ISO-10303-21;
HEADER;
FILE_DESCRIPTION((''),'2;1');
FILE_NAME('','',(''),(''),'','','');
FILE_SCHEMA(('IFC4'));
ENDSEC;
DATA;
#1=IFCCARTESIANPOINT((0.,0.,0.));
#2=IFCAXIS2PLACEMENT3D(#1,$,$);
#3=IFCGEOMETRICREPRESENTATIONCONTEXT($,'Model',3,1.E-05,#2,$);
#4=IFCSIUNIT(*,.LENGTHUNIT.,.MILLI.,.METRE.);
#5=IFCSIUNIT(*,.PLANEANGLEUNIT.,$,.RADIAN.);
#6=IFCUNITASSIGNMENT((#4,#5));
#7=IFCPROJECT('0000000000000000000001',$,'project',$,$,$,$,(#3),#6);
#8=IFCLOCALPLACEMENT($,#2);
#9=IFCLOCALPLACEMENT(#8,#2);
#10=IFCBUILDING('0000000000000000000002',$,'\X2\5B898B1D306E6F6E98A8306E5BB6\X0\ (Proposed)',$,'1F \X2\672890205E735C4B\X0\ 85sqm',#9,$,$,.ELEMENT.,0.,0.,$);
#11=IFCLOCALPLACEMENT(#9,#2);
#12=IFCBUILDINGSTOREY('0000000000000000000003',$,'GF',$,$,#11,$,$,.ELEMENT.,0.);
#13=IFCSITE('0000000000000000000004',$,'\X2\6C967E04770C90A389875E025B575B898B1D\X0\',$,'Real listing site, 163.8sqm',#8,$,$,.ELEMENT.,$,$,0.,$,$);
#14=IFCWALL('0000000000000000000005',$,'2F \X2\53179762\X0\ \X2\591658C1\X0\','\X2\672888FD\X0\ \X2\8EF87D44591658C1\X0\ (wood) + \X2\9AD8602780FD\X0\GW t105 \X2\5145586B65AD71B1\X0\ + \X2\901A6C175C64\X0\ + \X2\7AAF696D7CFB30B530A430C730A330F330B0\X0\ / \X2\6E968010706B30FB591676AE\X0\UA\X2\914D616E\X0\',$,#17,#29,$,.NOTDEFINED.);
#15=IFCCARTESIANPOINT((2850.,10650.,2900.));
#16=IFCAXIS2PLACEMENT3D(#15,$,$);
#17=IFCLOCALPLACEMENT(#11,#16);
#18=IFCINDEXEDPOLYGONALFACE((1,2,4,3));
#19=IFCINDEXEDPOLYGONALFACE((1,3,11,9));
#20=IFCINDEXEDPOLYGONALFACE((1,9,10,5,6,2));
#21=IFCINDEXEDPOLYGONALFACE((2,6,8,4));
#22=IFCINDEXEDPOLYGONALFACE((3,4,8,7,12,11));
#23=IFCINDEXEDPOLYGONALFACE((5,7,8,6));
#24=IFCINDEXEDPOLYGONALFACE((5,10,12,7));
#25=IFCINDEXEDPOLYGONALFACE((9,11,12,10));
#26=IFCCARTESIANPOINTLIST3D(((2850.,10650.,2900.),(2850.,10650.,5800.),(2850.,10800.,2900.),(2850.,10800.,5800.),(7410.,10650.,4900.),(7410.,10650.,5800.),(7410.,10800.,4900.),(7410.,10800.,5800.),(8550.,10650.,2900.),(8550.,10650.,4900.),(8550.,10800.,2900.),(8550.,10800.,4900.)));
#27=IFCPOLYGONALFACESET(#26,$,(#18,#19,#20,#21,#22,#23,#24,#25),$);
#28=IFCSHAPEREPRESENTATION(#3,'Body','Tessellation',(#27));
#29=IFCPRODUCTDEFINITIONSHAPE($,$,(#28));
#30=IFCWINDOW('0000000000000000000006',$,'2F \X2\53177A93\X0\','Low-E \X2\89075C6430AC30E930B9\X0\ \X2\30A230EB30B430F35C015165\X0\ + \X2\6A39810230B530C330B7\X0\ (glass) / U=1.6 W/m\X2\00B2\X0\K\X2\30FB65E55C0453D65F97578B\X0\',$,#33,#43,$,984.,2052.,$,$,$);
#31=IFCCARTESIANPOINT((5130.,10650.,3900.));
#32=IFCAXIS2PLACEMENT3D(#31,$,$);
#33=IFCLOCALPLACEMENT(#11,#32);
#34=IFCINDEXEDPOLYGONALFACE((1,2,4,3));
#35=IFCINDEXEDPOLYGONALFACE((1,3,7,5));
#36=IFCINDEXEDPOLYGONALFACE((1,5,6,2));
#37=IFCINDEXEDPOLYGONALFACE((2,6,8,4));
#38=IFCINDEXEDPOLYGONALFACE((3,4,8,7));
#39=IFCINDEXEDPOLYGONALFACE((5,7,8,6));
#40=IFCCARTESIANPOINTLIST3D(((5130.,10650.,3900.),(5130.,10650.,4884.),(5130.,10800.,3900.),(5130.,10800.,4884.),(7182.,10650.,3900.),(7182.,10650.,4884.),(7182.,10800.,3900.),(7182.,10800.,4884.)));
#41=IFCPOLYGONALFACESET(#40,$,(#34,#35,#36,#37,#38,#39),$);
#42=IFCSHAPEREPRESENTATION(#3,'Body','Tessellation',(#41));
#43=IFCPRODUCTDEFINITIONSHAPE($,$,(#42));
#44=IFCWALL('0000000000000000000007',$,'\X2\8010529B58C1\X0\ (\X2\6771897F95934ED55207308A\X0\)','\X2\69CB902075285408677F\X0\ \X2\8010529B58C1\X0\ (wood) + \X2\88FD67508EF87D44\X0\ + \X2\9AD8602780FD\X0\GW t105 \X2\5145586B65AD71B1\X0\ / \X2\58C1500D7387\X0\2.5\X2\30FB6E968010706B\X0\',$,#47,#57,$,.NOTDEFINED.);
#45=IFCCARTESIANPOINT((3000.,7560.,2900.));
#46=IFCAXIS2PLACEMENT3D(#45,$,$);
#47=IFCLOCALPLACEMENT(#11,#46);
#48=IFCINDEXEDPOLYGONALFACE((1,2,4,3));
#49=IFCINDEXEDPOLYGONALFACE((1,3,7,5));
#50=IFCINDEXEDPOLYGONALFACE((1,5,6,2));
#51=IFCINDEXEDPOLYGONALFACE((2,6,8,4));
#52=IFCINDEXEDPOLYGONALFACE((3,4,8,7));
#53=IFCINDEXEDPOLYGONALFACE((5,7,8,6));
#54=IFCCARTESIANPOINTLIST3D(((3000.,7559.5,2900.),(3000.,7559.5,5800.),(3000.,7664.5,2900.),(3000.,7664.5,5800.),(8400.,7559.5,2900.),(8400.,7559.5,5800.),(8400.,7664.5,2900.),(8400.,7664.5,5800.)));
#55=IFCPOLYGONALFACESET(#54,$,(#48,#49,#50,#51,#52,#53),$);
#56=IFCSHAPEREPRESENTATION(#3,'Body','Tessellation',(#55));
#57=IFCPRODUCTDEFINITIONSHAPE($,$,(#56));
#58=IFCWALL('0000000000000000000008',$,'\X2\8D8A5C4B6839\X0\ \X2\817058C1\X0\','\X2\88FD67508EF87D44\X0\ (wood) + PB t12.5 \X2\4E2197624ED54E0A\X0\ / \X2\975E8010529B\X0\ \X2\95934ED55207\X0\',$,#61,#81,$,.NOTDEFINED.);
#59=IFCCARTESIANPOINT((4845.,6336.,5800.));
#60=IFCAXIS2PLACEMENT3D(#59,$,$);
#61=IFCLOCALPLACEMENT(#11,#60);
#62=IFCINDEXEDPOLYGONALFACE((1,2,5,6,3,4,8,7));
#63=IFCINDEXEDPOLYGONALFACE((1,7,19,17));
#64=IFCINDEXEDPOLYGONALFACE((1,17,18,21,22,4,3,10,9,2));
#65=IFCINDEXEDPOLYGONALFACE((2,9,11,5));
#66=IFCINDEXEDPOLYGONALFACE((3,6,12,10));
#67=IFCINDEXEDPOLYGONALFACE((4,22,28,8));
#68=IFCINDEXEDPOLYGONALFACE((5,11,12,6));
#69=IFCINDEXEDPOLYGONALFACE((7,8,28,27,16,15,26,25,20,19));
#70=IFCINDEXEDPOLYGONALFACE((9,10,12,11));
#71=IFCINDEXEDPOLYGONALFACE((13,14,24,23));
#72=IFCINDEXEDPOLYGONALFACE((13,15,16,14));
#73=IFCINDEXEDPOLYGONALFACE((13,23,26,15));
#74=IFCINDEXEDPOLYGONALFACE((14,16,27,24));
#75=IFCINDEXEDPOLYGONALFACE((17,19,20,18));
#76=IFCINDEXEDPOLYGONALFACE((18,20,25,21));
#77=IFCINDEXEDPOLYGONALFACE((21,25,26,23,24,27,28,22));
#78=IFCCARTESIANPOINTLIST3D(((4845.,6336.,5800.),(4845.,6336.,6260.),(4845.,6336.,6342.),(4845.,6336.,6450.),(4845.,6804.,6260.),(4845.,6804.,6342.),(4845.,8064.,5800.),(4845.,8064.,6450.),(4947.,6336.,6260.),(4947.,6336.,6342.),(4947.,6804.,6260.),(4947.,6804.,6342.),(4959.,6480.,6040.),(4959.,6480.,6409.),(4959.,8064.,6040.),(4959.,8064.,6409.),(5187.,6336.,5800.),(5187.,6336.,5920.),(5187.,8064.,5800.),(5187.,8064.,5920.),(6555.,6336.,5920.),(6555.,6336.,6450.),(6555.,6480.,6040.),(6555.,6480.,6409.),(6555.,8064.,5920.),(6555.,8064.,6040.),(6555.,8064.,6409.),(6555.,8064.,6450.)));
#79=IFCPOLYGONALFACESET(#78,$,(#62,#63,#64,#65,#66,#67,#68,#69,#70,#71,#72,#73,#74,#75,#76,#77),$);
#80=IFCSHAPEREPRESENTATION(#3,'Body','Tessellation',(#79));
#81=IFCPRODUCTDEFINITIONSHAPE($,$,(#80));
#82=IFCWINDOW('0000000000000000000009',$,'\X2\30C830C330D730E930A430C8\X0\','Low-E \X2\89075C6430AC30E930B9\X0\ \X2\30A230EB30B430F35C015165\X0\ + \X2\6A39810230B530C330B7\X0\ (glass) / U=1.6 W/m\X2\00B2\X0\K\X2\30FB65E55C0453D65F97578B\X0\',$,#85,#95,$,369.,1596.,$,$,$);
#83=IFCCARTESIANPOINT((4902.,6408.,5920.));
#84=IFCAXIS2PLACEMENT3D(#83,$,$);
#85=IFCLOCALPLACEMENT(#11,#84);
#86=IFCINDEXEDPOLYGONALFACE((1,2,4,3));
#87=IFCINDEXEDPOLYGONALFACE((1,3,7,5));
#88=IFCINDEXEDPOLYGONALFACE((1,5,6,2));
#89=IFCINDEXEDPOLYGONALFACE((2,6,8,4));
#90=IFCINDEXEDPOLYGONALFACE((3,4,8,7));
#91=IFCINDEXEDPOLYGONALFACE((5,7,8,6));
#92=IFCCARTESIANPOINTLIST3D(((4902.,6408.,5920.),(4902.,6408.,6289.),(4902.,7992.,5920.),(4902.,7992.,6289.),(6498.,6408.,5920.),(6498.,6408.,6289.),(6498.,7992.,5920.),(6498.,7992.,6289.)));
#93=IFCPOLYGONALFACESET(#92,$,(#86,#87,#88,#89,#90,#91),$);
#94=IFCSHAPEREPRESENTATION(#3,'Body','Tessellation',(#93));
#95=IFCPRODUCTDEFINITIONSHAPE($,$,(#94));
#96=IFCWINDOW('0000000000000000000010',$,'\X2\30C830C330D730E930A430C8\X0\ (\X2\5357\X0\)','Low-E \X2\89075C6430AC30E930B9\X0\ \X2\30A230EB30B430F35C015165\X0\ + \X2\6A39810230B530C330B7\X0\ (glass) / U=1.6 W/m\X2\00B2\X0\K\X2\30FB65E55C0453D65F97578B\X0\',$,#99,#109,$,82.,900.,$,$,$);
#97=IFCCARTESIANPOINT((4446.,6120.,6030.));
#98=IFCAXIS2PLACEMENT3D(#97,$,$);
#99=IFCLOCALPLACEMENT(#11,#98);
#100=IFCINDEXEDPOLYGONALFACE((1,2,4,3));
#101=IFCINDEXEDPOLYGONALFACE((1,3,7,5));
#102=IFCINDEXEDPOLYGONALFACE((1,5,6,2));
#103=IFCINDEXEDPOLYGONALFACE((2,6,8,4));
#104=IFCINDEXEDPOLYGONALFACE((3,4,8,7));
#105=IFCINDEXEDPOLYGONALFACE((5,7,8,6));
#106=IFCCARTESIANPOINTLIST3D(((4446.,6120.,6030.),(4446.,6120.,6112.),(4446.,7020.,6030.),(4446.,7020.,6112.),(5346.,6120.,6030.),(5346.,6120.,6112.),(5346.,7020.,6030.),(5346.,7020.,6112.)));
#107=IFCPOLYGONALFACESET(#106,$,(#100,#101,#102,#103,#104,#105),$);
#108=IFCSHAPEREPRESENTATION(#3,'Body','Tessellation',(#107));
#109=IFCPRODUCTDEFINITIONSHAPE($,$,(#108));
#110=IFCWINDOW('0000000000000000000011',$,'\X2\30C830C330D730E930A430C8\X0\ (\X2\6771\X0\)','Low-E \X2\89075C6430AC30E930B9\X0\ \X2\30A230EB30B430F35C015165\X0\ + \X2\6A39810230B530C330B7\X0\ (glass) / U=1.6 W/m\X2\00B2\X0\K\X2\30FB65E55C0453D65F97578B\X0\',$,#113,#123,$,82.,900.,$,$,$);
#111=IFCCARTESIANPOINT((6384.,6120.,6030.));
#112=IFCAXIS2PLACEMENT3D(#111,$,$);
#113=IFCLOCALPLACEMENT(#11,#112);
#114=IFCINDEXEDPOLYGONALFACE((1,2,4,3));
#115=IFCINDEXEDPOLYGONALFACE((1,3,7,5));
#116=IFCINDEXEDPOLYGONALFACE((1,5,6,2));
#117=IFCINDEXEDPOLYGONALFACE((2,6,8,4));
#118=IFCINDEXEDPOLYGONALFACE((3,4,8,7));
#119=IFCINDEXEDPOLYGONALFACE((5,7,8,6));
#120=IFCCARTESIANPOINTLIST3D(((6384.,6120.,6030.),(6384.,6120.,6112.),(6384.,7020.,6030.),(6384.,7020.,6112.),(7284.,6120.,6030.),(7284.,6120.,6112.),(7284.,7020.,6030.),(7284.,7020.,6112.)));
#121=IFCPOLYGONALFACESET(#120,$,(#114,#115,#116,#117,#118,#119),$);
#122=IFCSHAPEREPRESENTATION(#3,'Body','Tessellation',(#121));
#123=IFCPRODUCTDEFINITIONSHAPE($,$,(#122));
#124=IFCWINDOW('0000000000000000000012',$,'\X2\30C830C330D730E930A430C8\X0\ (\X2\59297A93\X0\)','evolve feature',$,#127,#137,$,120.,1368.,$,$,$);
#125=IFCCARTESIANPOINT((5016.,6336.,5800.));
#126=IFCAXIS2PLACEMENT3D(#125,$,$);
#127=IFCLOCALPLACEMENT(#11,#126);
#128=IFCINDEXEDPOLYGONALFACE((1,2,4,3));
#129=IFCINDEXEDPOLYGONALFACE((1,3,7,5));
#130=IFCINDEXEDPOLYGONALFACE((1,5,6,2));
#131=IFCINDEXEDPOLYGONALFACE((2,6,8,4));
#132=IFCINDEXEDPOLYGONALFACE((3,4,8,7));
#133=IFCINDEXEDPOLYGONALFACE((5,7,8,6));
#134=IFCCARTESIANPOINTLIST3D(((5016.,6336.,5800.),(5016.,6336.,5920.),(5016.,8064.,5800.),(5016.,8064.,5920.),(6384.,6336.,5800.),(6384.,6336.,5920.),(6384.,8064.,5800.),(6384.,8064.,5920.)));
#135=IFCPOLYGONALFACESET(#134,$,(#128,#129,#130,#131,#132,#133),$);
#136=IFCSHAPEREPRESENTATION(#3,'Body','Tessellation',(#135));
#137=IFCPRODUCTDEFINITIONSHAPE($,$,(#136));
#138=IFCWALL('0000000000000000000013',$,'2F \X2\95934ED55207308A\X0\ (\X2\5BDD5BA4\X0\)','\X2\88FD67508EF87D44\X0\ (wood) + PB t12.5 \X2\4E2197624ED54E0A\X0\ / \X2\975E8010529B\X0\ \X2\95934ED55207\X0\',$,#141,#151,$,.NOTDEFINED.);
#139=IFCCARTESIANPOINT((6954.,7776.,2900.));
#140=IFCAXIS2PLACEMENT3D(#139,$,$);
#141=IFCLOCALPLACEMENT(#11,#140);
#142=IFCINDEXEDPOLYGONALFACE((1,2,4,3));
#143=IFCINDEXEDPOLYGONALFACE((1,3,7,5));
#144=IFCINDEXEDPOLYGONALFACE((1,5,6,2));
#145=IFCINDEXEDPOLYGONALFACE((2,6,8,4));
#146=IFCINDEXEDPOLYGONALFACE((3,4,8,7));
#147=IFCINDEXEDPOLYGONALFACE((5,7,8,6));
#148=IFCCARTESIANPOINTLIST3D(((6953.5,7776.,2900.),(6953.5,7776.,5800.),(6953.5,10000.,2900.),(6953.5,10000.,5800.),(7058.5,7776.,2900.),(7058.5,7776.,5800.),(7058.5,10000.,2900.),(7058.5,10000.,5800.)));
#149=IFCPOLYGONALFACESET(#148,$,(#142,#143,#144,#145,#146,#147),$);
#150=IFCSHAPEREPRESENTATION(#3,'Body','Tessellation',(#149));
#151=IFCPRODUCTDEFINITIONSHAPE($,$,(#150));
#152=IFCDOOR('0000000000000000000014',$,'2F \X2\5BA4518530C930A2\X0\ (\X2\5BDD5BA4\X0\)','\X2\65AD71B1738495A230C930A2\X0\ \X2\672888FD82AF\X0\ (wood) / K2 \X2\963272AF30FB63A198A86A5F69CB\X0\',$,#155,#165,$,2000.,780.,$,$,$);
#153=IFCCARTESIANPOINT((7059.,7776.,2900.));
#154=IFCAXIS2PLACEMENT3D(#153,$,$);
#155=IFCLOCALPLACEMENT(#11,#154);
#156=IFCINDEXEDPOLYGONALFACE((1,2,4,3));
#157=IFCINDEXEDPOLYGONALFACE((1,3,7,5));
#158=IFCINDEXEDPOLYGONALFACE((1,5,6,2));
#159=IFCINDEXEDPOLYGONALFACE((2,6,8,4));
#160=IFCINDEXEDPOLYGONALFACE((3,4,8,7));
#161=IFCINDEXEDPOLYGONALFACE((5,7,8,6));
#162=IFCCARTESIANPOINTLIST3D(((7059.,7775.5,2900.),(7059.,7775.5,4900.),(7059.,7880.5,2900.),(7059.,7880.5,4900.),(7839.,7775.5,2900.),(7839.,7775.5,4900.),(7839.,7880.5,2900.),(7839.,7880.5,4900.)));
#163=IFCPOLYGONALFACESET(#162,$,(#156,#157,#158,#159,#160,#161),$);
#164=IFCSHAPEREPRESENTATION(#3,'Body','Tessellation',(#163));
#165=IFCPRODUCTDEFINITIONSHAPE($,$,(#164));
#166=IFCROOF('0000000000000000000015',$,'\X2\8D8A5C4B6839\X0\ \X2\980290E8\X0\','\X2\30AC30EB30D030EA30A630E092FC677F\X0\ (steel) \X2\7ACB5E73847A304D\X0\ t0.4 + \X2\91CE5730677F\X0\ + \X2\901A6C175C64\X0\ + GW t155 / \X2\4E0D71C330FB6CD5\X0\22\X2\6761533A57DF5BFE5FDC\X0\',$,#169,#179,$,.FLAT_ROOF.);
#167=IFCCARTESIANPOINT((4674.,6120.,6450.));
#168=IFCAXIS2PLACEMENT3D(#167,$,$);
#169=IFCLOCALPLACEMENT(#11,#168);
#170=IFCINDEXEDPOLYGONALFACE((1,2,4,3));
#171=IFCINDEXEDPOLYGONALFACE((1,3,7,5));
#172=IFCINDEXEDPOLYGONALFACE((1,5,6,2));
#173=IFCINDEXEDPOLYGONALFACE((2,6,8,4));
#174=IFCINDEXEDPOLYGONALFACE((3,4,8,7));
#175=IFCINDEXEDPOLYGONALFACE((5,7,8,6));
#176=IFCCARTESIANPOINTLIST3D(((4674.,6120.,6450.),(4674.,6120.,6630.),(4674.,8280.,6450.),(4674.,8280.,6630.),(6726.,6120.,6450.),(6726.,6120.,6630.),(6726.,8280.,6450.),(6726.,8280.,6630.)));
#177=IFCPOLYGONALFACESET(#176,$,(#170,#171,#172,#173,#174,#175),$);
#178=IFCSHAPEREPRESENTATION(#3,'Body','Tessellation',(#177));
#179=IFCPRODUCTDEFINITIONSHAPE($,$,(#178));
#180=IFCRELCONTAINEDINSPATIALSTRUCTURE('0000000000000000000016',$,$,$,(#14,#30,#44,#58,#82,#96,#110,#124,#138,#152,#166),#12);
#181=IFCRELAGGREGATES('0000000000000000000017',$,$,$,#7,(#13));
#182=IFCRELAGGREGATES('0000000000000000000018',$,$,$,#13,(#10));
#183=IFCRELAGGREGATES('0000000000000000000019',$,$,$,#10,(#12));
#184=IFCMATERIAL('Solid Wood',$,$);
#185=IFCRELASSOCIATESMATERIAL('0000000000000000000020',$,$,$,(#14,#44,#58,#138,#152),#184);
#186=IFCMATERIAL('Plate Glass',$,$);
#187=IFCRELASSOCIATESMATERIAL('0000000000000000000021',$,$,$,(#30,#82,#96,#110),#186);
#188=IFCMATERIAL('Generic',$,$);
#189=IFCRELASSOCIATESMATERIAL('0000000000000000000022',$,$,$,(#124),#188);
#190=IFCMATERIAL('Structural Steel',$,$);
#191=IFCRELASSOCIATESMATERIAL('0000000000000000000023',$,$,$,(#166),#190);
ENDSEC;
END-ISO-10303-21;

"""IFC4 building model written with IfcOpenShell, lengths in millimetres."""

from ifc_helpers import new_model, si_unit, frame, frame_2d, origin, place, context, project, spatial, rectangle, extrude, material, element, fill, save


model = new_model("IFC4")

# Units and contexts
model_context = context("Model", 3, precision=1e-05, world=origin())
ifc_project = project(units=[si_unit("LENGTHUNIT", "METRE", prefix="MILLI"), si_unit("PLANEANGLEUNIT", "RADIAN")], contexts=[model_context])

# Site, building, storey
site_placement = place(None, origin())
site = spatial("IfcSite", under=ifc_project, at=site_placement, Name="沖縄県那覇市字安謝", ObjectType="Real listing site, 163.8sqm", CompositionType="ELEMENT", RefElevation=0.0)
building_placement = place(site_placement, origin())
building = spatial("IfcBuilding", under=site, at=building_placement, Name="安謝の潮風の家 (Proposed)", ObjectType="1F 木造平屋 85sqm", CompositionType="ELEMENT", ElevationOfRefHeight=0.0, ElevationOfTerrain=0.0)
storey_placement = place(building_placement, origin())
storey = spatial("IfcBuildingStorey", under=building, at=storey_placement, Name="GF", CompositionType="ELEMENT", Elevation=0.0)

# Wall, opening, window
ifc_material_1 = material(Name="Solid Wood")
wall_1_placement = place(storey_placement, frame((2850.0, 10650.0, 2900.0)))
wall_1 = element("IfcWall", 1, at=wall_1_placement, inside=storey, material=ifc_material_1, Name="2F 北面 外壁", Description="木製 軸組外壁 (wood) + 高性能GW t105 充填断熱 + 通気層 + 窯業系サイディング / 準耐火・外皮UA配慮", PredefinedType="NOTDEFINED", context=model_context, shape_type="SweptSolid", body=[
    extrude(rectangle(XDim=5700.0, YDim=150.0, at=frame_2d((2850.0, 75.0))), frame((2850.0, 10650.0, 2900.0)), (0.0, 0.0, 1.0), 2900.0),
])
opening_1_placement = place(storey_placement, frame((5130.0, 10650.0, 3900.0)))
opening_1 = element("IfcOpeningElement", 2, at=opening_1_placement, cuts=wall_1, PredefinedType="NOTDEFINED", context=model_context, shape_type="SweptSolid", body=[
    extrude(rectangle(XDim=2052.0, YDim=150.0, at=frame_2d((1026.0, 75.0))), frame((5130.0, 10650.0, 3900.0)), (0.0, 0.0, 1.0), 984.0),
])
ifc_material_2 = material(Name="Plate Glass")
window_1_placement = place(storey_placement, frame((5130.0, 10650.0, 3900.0)))
window_1 = element("IfcWindow", 3, at=window_1_placement, inside=storey, material=ifc_material_2, Name="2F 北窓", Description="Low-E 複層ガラス アルゴン封入 + 樹脂サッシ (glass) / U=1.6 W/m²K・日射取得型", OverallHeight=984.0, OverallWidth=2052.0, context=model_context, shape_type="SweptSolid", body=[
    extrude(rectangle(XDim=2052.0, YDim=150.0, at=frame_2d((1026.0, 75.0))), frame((5130.0, 10650.0, 3900.0)), (0.0, 0.0, 1.0), 984.0),
])
fill(opening_1, window_1)

# Wall
wall_2_placement = place(storey_placement, frame((3000.0, 7560.0, 2900.0)))
element("IfcWall", 4, at=wall_2_placement, inside=storey, material=ifc_material_1, Name="耐力壁 (東西間仕切り)", Description="構造用合板 耐力壁 (wood) + 製材軸組 + 高性能GW t105 充填断熱 / 壁倍率2.5・準耐火", PredefinedType="NOTDEFINED", context=model_context, shape_type="SweptSolid", body=[
    extrude(rectangle(XDim=5400.0, YDim=105.0, at=frame_2d((2700.0, 52.0))), frame((3000.0, 7560.0, 2900.0)), (0.0, 0.0, 1.0), 2900.0),
])

# Wall, openings, windows
wall_3_placement = place(storey_placement, frame((4845.0, 6336.0, 5800.0)))
wall_3 = element("IfcWall", 5, at=wall_3_placement, inside=storey, material=ifc_material_1, Name="越屋根 腰壁", Description="製材軸組 (wood) + PB t12.5 両面仕上 / 非耐力 間仕切", PredefinedType="NOTDEFINED", context=model_context, shape_type="SweptSolid", body=[
    extrude(rectangle(XDim=1710.0, YDim=1728.0, at=frame_2d((855.0, 864.0))), frame((4845.0, 6336.0, 5800.0)), (0.0, 0.0, 1.0), 650.0),
])
opening_2_placement = place(storey_placement, frame((4902.0, 6408.0, 5920.0)))
opening_2 = element("IfcOpeningElement", 6, at=opening_2_placement, cuts=wall_3, PredefinedType="NOTDEFINED", context=model_context, shape_type="SweptSolid", body=[
    extrude(rectangle(XDim=1596.0, YDim=1584.0, at=frame_2d((798.0, 792.0))), frame((4902.0, 6408.0, 5920.0)), (0.0, 0.0, 1.0), 369.0),
])
opening_3_placement = place(storey_placement, frame((4446.0, 6120.0, 6030.0)))
opening_3 = element("IfcOpeningElement", 7, at=opening_3_placement, cuts=wall_3, PredefinedType="NOTDEFINED", context=model_context, shape_type="SweptSolid", body=[
    extrude(rectangle(XDim=900.0, YDim=900.0, at=frame_2d((450.0, 450.0))), frame((4446.0, 6120.0, 6030.0)), (0.0, 0.0, 1.0), 82.0),
])
opening_4_placement = place(storey_placement, frame((6384.0, 6120.0, 6030.0)))
opening_4 = element("IfcOpeningElement", 8, at=opening_4_placement, cuts=wall_3, PredefinedType="NOTDEFINED", context=model_context, shape_type="SweptSolid", body=[
    extrude(rectangle(XDim=900.0, YDim=900.0, at=frame_2d((450.0, 450.0))), frame((6384.0, 6120.0, 6030.0)), (0.0, 0.0, 1.0), 82.0),
])
opening_5_placement = place(storey_placement, frame((5016.0, 6336.0, 5800.0)))
opening_5 = element("IfcOpeningElement", 9, at=opening_5_placement, cuts=wall_3, PredefinedType="NOTDEFINED", context=model_context, shape_type="SweptSolid", body=[
    extrude(rectangle(XDim=1368.0, YDim=1728.0, at=frame_2d((684.0, 864.0))), frame((5016.0, 6336.0, 5800.0)), (0.0, 0.0, 1.0), 120.0),
])
window_2_placement = place(storey_placement, frame((4902.0, 6408.0, 5920.0)))
window_2 = element("IfcWindow", 10, at=window_2_placement, inside=storey, material=ifc_material_2, Name="トップライト", Description="Low-E 複層ガラス アルゴン封入 + 樹脂サッシ (glass) / U=1.6 W/m²K・日射取得型", OverallHeight=369.0, OverallWidth=1596.0, context=model_context, shape_type="SweptSolid", body=[
    extrude(rectangle(XDim=1596.0, YDim=1584.0, at=frame_2d((798.0, 792.0))), frame((4902.0, 6408.0, 5920.0)), (0.0, 0.0, 1.0), 369.0),
])
fill(opening_2, window_2)
window_3_placement = place(storey_placement, frame((4446.0, 6120.0, 6030.0)))
window_3 = element("IfcWindow", 11, at=window_3_placement, inside=storey, material=ifc_material_2, Name="トップライト (南)", Description="Low-E 複層ガラス アルゴン封入 + 樹脂サッシ (glass) / U=1.6 W/m²K・日射取得型", OverallHeight=82.0, OverallWidth=900.0, context=model_context, shape_type="SweptSolid", body=[
    extrude(rectangle(XDim=900.0, YDim=900.0, at=frame_2d((450.0, 450.0))), frame((4446.0, 6120.0, 6030.0)), (0.0, 0.0, 1.0), 82.0),
])
fill(opening_3, window_3)
window_4_placement = place(storey_placement, frame((6384.0, 6120.0, 6030.0)))
window_4 = element("IfcWindow", 12, at=window_4_placement, inside=storey, material=ifc_material_2, Name="トップライト (東)", Description="Low-E 複層ガラス アルゴン封入 + 樹脂サッシ (glass) / U=1.6 W/m²K・日射取得型", OverallHeight=82.0, OverallWidth=900.0, context=model_context, shape_type="SweptSolid", body=[
    extrude(rectangle(XDim=900.0, YDim=900.0, at=frame_2d((450.0, 450.0))), frame((6384.0, 6120.0, 6030.0)), (0.0, 0.0, 1.0), 82.0),
])
fill(opening_4, window_4)
ifc_material_3 = material(Name="Generic")
window_5_placement = place(storey_placement, frame((5016.0, 6336.0, 5800.0)))
window_5 = element("IfcWindow", 13, at=window_5_placement, inside=storey, material=ifc_material_3, Name="トップライト (天窓)", Description="evolve feature", OverallHeight=120.0, OverallWidth=1368.0, context=model_context, shape_type="SweptSolid", body=[
    extrude(rectangle(XDim=1368.0, YDim=1728.0, at=frame_2d((684.0, 864.0))), frame((5016.0, 6336.0, 5800.0)), (0.0, 0.0, 1.0), 120.0),
])
fill(opening_5, window_5)

# Wall
wall_4_placement = place(storey_placement, frame((6954.0, 7776.0, 2900.0)))
element("IfcWall", 14, at=wall_4_placement, inside=storey, material=ifc_material_1, Name="2F 間仕切り (寝室)", Description="製材軸組 (wood) + PB t12.5 両面仕上 / 非耐力 間仕切", PredefinedType="NOTDEFINED", context=model_context, shape_type="SweptSolid", body=[
    extrude(rectangle(XDim=105.0, YDim=2224.0, at=frame_2d((52.0, 1112.0))), frame((6954.0, 7776.0, 2900.0)), (0.0, 0.0, 1.0), 2900.0),
])

# Door
door_placement = place(storey_placement, frame((7059.0, 7776.0, 2900.0)))
element("IfcDoor", 15, at=door_placement, inside=storey, material=ifc_material_1, Name="2F 室内ドア (寝室)", Description="断熱玄関ドア 木製芯 (wood) / K2 防犯・採風機構", OverallHeight=2000.0, OverallWidth=780.0, context=model_context, shape_type="SweptSolid", body=[
    extrude(rectangle(XDim=780.0, YDim=105.0, at=frame_2d((390.0, 52.0))), frame((7059.0, 7776.0, 2900.0)), (0.0, 0.0, 1.0), 2000.0),
])

# Roof
ifc_material_4 = material(Name="Structural Steel")
roof_placement = place(storey_placement, frame((4674.0, 6120.0, 6450.0)))
element("IfcRoof", 16, at=roof_placement, inside=storey, material=ifc_material_4, Name="越屋根 頂部", Description="ガルバリウム鋼板 (steel) 立平葺き t0.4 + 野地板 + 通気層 + GW t155 / 不燃・法22条区域対応", PredefinedType="FLAT_ROOF", context=model_context, shape_type="SweptSolid", body=[
    extrude(rectangle(XDim=2052.0, YDim=2160.0, at=frame_2d((1026.0, 1080.0))), frame((4674.0, 6120.0, 6450.0)), (0.0, 0.0, 1.0), 180.0),
])

save(model, "model.ifc")
